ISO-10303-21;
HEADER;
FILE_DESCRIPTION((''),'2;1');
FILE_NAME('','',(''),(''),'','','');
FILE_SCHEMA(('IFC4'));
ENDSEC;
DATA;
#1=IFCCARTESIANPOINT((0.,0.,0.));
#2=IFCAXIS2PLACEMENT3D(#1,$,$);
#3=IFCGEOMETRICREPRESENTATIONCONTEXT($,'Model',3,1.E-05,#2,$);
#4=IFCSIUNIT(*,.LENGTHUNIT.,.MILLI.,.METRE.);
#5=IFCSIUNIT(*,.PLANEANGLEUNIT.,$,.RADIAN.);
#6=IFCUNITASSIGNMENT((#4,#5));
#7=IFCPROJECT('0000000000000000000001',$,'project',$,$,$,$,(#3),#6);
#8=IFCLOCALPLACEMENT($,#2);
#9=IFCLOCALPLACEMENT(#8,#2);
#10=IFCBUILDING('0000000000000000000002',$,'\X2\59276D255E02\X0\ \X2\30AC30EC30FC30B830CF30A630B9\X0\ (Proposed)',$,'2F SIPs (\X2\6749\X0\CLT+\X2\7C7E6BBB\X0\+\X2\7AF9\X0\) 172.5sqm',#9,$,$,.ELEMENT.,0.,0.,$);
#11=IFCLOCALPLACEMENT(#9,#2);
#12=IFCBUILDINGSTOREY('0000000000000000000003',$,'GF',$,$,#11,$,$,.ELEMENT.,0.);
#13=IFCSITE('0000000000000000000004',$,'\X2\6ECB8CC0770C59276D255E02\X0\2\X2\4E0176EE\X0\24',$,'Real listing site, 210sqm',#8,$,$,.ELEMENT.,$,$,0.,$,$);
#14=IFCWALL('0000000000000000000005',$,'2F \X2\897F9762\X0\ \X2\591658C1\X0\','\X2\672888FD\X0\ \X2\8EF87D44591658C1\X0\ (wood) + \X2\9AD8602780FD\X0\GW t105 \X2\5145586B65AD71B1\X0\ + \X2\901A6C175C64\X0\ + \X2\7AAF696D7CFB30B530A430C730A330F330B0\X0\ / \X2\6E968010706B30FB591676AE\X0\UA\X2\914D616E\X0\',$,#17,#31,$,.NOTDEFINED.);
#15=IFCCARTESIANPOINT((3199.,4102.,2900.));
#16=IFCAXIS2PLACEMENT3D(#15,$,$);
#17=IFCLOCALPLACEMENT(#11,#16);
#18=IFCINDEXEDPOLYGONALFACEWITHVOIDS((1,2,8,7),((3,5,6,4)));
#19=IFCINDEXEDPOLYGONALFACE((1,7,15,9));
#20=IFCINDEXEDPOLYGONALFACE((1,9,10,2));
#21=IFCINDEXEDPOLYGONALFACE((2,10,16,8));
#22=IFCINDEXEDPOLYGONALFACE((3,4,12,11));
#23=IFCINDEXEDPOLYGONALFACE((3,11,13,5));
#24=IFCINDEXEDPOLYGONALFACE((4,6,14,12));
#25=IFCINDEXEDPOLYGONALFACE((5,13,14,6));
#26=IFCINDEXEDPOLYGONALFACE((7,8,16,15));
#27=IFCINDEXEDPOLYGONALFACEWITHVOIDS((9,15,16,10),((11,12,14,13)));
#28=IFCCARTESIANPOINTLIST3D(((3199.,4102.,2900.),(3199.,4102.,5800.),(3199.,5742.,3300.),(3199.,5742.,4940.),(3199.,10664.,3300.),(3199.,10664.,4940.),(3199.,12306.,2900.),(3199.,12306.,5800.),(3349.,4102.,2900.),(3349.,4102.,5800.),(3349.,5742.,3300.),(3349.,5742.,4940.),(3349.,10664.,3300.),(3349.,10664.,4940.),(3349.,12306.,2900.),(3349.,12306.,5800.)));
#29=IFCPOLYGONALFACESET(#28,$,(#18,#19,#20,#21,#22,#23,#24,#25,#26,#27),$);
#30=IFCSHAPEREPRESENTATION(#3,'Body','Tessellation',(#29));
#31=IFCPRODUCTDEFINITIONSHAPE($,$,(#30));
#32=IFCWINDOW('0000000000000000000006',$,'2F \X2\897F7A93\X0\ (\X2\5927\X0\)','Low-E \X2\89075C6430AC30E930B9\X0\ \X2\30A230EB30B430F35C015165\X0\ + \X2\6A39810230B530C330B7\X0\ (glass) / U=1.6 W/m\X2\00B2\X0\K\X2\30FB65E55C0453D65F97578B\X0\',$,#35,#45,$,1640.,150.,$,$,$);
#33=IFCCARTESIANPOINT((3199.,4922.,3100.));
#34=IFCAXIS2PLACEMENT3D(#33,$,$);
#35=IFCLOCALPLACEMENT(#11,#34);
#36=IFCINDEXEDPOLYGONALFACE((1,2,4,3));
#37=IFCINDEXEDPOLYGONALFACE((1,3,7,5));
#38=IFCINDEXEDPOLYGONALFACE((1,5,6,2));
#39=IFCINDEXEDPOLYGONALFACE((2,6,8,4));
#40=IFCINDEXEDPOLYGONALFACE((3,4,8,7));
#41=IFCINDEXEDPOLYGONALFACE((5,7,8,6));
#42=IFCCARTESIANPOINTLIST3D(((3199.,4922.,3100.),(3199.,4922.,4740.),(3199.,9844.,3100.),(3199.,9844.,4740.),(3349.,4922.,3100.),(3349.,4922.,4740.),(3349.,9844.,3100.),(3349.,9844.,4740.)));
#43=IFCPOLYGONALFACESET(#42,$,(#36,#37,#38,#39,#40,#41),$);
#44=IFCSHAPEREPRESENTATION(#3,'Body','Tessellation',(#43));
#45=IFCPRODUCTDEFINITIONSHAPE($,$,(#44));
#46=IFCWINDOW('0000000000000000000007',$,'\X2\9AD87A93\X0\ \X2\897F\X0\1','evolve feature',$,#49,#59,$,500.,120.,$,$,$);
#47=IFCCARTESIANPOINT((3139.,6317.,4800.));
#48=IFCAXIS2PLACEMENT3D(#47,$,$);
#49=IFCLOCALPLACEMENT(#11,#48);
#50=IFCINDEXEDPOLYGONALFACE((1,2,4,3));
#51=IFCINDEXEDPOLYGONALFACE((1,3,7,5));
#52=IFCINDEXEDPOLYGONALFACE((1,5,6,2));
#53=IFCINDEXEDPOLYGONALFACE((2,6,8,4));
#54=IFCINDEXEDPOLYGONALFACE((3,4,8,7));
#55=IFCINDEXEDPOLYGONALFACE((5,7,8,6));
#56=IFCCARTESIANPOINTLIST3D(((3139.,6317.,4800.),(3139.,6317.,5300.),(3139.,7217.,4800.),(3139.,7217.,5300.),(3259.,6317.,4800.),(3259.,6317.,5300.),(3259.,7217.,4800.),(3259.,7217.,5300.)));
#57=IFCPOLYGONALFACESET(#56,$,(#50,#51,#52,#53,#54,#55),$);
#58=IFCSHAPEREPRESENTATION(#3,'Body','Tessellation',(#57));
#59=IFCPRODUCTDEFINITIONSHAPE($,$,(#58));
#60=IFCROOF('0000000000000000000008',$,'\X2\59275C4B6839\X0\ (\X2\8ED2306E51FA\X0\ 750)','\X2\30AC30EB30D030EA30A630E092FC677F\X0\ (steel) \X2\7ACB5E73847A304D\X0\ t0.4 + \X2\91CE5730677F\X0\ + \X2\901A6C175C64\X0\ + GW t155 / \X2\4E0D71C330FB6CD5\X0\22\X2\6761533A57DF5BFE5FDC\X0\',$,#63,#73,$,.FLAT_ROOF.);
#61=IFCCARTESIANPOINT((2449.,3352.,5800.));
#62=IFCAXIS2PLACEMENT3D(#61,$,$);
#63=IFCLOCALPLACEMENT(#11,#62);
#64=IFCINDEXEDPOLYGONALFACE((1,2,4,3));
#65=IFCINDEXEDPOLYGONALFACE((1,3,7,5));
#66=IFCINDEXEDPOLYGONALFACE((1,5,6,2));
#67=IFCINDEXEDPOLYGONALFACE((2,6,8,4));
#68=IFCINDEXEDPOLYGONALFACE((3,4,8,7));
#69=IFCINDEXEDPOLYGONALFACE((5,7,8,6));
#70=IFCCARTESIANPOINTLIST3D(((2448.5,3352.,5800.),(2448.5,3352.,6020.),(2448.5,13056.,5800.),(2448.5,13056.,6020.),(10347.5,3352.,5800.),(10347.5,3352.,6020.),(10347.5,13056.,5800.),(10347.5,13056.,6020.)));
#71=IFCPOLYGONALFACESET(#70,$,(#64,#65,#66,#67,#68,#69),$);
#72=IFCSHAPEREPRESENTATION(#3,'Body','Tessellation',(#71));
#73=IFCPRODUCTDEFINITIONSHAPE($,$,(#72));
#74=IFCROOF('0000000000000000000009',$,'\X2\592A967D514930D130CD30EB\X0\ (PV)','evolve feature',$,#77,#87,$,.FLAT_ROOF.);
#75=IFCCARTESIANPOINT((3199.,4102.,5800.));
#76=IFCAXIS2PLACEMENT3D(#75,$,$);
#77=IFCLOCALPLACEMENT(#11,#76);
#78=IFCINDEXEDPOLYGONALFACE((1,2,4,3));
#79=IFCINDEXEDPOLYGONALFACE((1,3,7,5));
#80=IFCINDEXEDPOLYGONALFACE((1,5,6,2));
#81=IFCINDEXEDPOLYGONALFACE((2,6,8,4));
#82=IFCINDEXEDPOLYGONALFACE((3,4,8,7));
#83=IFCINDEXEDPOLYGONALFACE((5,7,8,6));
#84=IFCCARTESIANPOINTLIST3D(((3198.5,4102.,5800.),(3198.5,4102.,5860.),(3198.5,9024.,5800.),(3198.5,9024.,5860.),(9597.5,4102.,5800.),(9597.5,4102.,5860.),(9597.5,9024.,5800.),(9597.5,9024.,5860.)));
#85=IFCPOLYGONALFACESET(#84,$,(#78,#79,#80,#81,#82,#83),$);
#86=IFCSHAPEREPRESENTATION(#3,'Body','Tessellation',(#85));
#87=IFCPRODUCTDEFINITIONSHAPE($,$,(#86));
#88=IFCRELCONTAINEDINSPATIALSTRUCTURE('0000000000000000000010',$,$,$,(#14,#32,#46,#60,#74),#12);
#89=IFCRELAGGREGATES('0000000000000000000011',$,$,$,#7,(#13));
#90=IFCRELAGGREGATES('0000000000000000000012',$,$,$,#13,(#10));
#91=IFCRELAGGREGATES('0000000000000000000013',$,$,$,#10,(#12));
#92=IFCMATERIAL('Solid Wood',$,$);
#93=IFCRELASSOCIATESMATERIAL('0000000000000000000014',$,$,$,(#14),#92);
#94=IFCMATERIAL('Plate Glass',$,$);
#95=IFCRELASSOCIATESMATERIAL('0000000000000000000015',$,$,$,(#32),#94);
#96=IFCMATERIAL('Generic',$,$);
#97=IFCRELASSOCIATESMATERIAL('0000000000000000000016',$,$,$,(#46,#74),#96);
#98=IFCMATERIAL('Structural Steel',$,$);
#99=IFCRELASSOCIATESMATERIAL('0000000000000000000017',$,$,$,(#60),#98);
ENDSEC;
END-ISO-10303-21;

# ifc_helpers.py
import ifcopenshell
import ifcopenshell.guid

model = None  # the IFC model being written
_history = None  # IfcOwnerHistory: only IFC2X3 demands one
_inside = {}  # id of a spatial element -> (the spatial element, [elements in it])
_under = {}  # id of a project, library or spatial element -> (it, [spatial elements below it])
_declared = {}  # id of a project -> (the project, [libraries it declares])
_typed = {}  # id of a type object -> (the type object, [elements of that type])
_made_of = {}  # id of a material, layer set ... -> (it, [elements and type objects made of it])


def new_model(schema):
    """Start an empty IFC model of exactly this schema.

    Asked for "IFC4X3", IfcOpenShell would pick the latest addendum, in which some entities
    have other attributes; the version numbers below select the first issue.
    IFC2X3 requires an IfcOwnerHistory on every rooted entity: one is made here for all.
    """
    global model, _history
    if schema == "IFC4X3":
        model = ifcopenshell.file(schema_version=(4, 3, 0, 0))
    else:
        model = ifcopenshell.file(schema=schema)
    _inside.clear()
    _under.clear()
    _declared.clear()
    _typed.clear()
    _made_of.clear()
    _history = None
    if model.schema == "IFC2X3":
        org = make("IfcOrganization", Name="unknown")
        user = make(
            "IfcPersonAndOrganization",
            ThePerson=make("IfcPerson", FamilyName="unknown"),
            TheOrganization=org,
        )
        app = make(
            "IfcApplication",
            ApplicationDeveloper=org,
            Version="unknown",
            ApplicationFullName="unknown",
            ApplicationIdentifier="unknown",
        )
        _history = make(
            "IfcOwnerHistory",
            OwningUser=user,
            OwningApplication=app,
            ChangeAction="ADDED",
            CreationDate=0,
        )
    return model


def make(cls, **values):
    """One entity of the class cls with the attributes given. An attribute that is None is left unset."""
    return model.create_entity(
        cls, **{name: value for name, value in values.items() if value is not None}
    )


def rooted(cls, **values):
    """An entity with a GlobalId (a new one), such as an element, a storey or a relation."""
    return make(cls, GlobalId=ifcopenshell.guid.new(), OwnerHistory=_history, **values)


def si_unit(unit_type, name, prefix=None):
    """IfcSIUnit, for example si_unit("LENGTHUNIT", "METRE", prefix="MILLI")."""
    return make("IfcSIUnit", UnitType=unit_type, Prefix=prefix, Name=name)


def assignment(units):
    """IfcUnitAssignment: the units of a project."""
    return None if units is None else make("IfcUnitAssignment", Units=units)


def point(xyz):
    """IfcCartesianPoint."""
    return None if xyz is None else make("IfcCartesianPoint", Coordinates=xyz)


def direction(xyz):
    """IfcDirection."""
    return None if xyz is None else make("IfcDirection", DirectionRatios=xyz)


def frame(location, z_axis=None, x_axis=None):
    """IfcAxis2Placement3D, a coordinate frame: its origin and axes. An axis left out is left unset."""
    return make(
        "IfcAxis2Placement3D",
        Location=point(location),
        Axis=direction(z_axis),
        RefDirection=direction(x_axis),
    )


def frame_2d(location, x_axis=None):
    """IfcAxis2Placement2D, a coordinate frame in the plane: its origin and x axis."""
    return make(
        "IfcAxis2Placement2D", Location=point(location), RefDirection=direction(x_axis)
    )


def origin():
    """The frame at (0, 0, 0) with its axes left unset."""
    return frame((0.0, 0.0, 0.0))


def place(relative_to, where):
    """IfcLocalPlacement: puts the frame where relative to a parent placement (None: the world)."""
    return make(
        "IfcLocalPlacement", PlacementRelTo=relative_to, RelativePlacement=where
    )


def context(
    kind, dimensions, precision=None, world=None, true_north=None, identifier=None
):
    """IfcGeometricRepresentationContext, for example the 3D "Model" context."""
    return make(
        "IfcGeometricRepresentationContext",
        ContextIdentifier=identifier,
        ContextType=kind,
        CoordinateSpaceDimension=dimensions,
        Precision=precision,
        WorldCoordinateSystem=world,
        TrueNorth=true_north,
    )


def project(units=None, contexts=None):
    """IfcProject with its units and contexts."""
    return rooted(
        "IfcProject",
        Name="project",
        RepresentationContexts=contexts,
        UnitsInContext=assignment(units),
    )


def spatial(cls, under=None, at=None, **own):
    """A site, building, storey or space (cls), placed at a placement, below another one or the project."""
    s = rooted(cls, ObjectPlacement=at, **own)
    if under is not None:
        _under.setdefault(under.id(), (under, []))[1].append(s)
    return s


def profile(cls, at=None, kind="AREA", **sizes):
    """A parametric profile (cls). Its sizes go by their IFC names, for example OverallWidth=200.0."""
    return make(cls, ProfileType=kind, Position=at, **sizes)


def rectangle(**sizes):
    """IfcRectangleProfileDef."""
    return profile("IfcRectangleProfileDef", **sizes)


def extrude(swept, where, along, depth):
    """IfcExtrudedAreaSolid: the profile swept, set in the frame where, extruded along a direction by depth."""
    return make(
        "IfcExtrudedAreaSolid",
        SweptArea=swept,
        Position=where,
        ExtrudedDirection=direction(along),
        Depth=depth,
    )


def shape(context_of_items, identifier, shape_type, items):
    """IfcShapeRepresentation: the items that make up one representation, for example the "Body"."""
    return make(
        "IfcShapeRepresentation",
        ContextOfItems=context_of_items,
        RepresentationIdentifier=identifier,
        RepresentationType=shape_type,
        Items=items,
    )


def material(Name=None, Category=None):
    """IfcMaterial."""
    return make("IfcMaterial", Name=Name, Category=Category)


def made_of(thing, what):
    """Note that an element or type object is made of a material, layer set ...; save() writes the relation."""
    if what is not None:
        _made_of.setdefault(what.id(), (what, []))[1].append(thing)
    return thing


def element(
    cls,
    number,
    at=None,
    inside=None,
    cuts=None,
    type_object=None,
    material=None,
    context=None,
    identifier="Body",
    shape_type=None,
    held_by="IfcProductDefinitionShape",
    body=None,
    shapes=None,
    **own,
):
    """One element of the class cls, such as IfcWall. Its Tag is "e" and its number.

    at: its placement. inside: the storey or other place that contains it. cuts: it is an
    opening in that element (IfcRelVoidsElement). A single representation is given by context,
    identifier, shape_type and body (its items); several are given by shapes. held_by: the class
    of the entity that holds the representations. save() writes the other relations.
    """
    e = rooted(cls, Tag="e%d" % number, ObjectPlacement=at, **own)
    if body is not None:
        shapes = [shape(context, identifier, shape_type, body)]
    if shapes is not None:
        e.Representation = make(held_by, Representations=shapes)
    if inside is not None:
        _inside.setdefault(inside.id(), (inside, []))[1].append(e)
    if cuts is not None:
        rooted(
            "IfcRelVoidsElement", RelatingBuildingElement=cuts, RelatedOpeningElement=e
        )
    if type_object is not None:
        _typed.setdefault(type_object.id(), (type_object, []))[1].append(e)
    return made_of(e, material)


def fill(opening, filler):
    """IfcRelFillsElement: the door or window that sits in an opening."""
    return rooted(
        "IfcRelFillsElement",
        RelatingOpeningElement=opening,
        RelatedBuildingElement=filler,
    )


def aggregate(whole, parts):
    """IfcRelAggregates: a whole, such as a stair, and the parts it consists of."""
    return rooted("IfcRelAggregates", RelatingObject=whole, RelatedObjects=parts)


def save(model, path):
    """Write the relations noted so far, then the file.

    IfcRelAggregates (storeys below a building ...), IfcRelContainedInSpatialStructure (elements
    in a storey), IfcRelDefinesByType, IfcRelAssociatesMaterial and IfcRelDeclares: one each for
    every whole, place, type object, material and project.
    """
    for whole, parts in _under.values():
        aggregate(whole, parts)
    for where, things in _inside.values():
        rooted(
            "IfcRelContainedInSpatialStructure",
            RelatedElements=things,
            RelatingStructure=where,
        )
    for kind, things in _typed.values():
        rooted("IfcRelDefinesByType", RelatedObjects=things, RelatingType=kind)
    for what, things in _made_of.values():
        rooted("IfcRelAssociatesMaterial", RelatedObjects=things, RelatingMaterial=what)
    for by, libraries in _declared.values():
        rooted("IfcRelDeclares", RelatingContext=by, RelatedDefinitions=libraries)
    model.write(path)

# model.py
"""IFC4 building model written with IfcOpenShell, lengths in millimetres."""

from ifc_helpers import new_model, si_unit, frame, frame_2d, origin, place, context, project, spatial, rectangle, extrude, material, element, fill, save


model = new_model("IFC4")

# Units and contexts
model_context = context("Model", 3, precision=1e-05, world=origin())
ifc_project = project(units=[si_unit("LENGTHUNIT", "METRE", prefix="MILLI"), si_unit("PLANEANGLEUNIT", "RADIAN")], contexts=[model_context])

# Site, building, storey
site_placement = place(None, origin())
site = spatial("IfcSite", under=ifc_project, at=site_placement, Name="滋賀県大津市2丁目24", ObjectType="Real listing site, 210sqm", CompositionType="ELEMENT", RefElevation=0.0)
building_placement = place(site_placement, origin())
building = spatial("IfcBuilding", under=site, at=building_placement, Name="大津市 ガレージハウス (Proposed)", ObjectType="2F SIPs (杉CLT+籾殻+竹) 172.5sqm", CompositionType="ELEMENT", ElevationOfRefHeight=0.0, ElevationOfTerrain=0.0)
storey_placement = place(building_placement, origin())
storey = spatial("IfcBuildingStorey", under=building, at=storey_placement, Name="GF", CompositionType="ELEMENT", Elevation=0.0)

# Shared definitions
ifc_material_1 = material(Name="Solid Wood")
ifc_material_2 = material(Name="Generic")

# Shared definitions
ifc_material_3 = material(Name="Plate Glass")

# Wall, openings, windows
wall_1_placement = place(storey_placement, frame((3199.0, 4102.0, 2900.0)))
wall_1 = element("IfcWall", 1, at=wall_1_placement, inside=storey, material=ifc_material_1, Name="2F 西面 外壁", Description="木製 軸組外壁 (wood) + 高性能GW t105 充填断熱 + 通気層 + 窯業系サイディング / 準耐火・外皮UA配慮", PredefinedType="NOTDEFINED", context=model_context, shape_type="SweptSolid", body=[
    extrude(rectangle(XDim=150.0, YDim=8204.0, at=frame_2d((75.0, 4102.0))), frame((3199.0, 4102.0, 2900.0)), (0.0, 0.0, 1.0), 2900.0),
])
opening_1_placement = place(storey_placement, frame((3199.0, 4922.0, 3100.0)))
opening_1 = element("IfcOpeningElement", 2, at=opening_1_placement, cuts=wall_1, PredefinedType="NOTDEFINED", context=model_context, shape_type="SweptSolid", body=[
    extrude(rectangle(XDim=150.0, YDim=4922.0, at=frame_2d((75.0, 2461.0))), frame((3199.0, 4922.0, 3100.0)), (0.0, 0.0, 1.0), 1640.0),
])
opening_2_placement = place(storey_placement, frame((3139.0, 6317.0, 4800.0)))
opening_2 = element("IfcOpeningElement", 3, at=opening_2_placement, cuts=wall_1, PredefinedType="NOTDEFINED", context=model_context, shape_type="SweptSolid", body=[
    extrude(rectangle(XDim=120.0, YDim=900.0, at=frame_2d((60.0, 450.0))), frame((3139.0, 6317.0, 4800.0)), (0.0, 0.0, 1.0), 500.0),
])
window_1_placement = place(storey_placement, frame((3199.0, 4922.0, 3100.0)))
window_1 = element("IfcWindow", 4, at=window_1_placement, inside=storey, material=ifc_material_3, Name="2F 西窓 (大)", Description="Low-E 複層ガラス アルゴン封入 + 樹脂サッシ (glass) / U=1.6 W/m²K・日射取得型", OverallHeight=1640.0, OverallWidth=150.0, context=model_context, shape_type="SweptSolid", body=[
    extrude(rectangle(XDim=150.0, YDim=4922.0, at=frame_2d((75.0, 2461.0))), frame((3199.0, 4922.0, 3100.0)), (0.0, 0.0, 1.0), 1640.0),
])
fill(opening_1, window_1)
window_2_placement = place(storey_placement, frame((3139.0, 6317.0, 4800.0)))
window_2 = element("IfcWindow", 5, at=window_2_placement, inside=storey, material=ifc_material_2, Name="高窓 西1", Description="evolve feature", OverallHeight=500.0, OverallWidth=120.0, context=model_context, shape_type="SweptSolid", body=[
    extrude(rectangle(XDim=120.0, YDim=900.0, at=frame_2d((60.0, 450.0))), frame((3139.0, 6317.0, 4800.0)), (0.0, 0.0, 1.0), 500.0),
])
fill(opening_2, window_2)

# Roofs
ifc_material_4 = material(Name="Structural Steel")
roof_1_placement = place(storey_placement, frame((2449.0, 3352.0, 5800.0)))
element("IfcRoof", 6, at=roof_1_placement, inside=storey, material=ifc_material_4, Name="大屋根 (軒の出 750)", Description="ガルバリウム鋼板 (steel) 立平葺き t0.4 + 野地板 + 通気層 + GW t155 / 不燃・法22条区域対応", PredefinedType="FLAT_ROOF", context=model_context, shape_type="SweptSolid", body=[
    extrude(rectangle(XDim=7899.0, YDim=9704.0, at=frame_2d((3949.0, 4852.0))), frame((2449.0, 3352.0, 5800.0)), (0.0, 0.0, 1.0), 220.0),
])
roof_2_placement = place(storey_placement, frame((3199.0, 4102.0, 5800.0)))
element("IfcRoof", 7, at=roof_2_placement, inside=storey, material=ifc_material_2, Name="太陽光パネル (PV)", Description="evolve feature", PredefinedType="FLAT_ROOF", context=model_context, shape_type="SweptSolid", body=[
    extrude(rectangle(XDim=6399.0, YDim=4922.0, at=frame_2d((3199.0, 2461.0))), frame((3199.0, 4102.0, 5800.0)), (0.0, 0.0, 1.0), 60.0),
])

save(model, "model.ifc")
